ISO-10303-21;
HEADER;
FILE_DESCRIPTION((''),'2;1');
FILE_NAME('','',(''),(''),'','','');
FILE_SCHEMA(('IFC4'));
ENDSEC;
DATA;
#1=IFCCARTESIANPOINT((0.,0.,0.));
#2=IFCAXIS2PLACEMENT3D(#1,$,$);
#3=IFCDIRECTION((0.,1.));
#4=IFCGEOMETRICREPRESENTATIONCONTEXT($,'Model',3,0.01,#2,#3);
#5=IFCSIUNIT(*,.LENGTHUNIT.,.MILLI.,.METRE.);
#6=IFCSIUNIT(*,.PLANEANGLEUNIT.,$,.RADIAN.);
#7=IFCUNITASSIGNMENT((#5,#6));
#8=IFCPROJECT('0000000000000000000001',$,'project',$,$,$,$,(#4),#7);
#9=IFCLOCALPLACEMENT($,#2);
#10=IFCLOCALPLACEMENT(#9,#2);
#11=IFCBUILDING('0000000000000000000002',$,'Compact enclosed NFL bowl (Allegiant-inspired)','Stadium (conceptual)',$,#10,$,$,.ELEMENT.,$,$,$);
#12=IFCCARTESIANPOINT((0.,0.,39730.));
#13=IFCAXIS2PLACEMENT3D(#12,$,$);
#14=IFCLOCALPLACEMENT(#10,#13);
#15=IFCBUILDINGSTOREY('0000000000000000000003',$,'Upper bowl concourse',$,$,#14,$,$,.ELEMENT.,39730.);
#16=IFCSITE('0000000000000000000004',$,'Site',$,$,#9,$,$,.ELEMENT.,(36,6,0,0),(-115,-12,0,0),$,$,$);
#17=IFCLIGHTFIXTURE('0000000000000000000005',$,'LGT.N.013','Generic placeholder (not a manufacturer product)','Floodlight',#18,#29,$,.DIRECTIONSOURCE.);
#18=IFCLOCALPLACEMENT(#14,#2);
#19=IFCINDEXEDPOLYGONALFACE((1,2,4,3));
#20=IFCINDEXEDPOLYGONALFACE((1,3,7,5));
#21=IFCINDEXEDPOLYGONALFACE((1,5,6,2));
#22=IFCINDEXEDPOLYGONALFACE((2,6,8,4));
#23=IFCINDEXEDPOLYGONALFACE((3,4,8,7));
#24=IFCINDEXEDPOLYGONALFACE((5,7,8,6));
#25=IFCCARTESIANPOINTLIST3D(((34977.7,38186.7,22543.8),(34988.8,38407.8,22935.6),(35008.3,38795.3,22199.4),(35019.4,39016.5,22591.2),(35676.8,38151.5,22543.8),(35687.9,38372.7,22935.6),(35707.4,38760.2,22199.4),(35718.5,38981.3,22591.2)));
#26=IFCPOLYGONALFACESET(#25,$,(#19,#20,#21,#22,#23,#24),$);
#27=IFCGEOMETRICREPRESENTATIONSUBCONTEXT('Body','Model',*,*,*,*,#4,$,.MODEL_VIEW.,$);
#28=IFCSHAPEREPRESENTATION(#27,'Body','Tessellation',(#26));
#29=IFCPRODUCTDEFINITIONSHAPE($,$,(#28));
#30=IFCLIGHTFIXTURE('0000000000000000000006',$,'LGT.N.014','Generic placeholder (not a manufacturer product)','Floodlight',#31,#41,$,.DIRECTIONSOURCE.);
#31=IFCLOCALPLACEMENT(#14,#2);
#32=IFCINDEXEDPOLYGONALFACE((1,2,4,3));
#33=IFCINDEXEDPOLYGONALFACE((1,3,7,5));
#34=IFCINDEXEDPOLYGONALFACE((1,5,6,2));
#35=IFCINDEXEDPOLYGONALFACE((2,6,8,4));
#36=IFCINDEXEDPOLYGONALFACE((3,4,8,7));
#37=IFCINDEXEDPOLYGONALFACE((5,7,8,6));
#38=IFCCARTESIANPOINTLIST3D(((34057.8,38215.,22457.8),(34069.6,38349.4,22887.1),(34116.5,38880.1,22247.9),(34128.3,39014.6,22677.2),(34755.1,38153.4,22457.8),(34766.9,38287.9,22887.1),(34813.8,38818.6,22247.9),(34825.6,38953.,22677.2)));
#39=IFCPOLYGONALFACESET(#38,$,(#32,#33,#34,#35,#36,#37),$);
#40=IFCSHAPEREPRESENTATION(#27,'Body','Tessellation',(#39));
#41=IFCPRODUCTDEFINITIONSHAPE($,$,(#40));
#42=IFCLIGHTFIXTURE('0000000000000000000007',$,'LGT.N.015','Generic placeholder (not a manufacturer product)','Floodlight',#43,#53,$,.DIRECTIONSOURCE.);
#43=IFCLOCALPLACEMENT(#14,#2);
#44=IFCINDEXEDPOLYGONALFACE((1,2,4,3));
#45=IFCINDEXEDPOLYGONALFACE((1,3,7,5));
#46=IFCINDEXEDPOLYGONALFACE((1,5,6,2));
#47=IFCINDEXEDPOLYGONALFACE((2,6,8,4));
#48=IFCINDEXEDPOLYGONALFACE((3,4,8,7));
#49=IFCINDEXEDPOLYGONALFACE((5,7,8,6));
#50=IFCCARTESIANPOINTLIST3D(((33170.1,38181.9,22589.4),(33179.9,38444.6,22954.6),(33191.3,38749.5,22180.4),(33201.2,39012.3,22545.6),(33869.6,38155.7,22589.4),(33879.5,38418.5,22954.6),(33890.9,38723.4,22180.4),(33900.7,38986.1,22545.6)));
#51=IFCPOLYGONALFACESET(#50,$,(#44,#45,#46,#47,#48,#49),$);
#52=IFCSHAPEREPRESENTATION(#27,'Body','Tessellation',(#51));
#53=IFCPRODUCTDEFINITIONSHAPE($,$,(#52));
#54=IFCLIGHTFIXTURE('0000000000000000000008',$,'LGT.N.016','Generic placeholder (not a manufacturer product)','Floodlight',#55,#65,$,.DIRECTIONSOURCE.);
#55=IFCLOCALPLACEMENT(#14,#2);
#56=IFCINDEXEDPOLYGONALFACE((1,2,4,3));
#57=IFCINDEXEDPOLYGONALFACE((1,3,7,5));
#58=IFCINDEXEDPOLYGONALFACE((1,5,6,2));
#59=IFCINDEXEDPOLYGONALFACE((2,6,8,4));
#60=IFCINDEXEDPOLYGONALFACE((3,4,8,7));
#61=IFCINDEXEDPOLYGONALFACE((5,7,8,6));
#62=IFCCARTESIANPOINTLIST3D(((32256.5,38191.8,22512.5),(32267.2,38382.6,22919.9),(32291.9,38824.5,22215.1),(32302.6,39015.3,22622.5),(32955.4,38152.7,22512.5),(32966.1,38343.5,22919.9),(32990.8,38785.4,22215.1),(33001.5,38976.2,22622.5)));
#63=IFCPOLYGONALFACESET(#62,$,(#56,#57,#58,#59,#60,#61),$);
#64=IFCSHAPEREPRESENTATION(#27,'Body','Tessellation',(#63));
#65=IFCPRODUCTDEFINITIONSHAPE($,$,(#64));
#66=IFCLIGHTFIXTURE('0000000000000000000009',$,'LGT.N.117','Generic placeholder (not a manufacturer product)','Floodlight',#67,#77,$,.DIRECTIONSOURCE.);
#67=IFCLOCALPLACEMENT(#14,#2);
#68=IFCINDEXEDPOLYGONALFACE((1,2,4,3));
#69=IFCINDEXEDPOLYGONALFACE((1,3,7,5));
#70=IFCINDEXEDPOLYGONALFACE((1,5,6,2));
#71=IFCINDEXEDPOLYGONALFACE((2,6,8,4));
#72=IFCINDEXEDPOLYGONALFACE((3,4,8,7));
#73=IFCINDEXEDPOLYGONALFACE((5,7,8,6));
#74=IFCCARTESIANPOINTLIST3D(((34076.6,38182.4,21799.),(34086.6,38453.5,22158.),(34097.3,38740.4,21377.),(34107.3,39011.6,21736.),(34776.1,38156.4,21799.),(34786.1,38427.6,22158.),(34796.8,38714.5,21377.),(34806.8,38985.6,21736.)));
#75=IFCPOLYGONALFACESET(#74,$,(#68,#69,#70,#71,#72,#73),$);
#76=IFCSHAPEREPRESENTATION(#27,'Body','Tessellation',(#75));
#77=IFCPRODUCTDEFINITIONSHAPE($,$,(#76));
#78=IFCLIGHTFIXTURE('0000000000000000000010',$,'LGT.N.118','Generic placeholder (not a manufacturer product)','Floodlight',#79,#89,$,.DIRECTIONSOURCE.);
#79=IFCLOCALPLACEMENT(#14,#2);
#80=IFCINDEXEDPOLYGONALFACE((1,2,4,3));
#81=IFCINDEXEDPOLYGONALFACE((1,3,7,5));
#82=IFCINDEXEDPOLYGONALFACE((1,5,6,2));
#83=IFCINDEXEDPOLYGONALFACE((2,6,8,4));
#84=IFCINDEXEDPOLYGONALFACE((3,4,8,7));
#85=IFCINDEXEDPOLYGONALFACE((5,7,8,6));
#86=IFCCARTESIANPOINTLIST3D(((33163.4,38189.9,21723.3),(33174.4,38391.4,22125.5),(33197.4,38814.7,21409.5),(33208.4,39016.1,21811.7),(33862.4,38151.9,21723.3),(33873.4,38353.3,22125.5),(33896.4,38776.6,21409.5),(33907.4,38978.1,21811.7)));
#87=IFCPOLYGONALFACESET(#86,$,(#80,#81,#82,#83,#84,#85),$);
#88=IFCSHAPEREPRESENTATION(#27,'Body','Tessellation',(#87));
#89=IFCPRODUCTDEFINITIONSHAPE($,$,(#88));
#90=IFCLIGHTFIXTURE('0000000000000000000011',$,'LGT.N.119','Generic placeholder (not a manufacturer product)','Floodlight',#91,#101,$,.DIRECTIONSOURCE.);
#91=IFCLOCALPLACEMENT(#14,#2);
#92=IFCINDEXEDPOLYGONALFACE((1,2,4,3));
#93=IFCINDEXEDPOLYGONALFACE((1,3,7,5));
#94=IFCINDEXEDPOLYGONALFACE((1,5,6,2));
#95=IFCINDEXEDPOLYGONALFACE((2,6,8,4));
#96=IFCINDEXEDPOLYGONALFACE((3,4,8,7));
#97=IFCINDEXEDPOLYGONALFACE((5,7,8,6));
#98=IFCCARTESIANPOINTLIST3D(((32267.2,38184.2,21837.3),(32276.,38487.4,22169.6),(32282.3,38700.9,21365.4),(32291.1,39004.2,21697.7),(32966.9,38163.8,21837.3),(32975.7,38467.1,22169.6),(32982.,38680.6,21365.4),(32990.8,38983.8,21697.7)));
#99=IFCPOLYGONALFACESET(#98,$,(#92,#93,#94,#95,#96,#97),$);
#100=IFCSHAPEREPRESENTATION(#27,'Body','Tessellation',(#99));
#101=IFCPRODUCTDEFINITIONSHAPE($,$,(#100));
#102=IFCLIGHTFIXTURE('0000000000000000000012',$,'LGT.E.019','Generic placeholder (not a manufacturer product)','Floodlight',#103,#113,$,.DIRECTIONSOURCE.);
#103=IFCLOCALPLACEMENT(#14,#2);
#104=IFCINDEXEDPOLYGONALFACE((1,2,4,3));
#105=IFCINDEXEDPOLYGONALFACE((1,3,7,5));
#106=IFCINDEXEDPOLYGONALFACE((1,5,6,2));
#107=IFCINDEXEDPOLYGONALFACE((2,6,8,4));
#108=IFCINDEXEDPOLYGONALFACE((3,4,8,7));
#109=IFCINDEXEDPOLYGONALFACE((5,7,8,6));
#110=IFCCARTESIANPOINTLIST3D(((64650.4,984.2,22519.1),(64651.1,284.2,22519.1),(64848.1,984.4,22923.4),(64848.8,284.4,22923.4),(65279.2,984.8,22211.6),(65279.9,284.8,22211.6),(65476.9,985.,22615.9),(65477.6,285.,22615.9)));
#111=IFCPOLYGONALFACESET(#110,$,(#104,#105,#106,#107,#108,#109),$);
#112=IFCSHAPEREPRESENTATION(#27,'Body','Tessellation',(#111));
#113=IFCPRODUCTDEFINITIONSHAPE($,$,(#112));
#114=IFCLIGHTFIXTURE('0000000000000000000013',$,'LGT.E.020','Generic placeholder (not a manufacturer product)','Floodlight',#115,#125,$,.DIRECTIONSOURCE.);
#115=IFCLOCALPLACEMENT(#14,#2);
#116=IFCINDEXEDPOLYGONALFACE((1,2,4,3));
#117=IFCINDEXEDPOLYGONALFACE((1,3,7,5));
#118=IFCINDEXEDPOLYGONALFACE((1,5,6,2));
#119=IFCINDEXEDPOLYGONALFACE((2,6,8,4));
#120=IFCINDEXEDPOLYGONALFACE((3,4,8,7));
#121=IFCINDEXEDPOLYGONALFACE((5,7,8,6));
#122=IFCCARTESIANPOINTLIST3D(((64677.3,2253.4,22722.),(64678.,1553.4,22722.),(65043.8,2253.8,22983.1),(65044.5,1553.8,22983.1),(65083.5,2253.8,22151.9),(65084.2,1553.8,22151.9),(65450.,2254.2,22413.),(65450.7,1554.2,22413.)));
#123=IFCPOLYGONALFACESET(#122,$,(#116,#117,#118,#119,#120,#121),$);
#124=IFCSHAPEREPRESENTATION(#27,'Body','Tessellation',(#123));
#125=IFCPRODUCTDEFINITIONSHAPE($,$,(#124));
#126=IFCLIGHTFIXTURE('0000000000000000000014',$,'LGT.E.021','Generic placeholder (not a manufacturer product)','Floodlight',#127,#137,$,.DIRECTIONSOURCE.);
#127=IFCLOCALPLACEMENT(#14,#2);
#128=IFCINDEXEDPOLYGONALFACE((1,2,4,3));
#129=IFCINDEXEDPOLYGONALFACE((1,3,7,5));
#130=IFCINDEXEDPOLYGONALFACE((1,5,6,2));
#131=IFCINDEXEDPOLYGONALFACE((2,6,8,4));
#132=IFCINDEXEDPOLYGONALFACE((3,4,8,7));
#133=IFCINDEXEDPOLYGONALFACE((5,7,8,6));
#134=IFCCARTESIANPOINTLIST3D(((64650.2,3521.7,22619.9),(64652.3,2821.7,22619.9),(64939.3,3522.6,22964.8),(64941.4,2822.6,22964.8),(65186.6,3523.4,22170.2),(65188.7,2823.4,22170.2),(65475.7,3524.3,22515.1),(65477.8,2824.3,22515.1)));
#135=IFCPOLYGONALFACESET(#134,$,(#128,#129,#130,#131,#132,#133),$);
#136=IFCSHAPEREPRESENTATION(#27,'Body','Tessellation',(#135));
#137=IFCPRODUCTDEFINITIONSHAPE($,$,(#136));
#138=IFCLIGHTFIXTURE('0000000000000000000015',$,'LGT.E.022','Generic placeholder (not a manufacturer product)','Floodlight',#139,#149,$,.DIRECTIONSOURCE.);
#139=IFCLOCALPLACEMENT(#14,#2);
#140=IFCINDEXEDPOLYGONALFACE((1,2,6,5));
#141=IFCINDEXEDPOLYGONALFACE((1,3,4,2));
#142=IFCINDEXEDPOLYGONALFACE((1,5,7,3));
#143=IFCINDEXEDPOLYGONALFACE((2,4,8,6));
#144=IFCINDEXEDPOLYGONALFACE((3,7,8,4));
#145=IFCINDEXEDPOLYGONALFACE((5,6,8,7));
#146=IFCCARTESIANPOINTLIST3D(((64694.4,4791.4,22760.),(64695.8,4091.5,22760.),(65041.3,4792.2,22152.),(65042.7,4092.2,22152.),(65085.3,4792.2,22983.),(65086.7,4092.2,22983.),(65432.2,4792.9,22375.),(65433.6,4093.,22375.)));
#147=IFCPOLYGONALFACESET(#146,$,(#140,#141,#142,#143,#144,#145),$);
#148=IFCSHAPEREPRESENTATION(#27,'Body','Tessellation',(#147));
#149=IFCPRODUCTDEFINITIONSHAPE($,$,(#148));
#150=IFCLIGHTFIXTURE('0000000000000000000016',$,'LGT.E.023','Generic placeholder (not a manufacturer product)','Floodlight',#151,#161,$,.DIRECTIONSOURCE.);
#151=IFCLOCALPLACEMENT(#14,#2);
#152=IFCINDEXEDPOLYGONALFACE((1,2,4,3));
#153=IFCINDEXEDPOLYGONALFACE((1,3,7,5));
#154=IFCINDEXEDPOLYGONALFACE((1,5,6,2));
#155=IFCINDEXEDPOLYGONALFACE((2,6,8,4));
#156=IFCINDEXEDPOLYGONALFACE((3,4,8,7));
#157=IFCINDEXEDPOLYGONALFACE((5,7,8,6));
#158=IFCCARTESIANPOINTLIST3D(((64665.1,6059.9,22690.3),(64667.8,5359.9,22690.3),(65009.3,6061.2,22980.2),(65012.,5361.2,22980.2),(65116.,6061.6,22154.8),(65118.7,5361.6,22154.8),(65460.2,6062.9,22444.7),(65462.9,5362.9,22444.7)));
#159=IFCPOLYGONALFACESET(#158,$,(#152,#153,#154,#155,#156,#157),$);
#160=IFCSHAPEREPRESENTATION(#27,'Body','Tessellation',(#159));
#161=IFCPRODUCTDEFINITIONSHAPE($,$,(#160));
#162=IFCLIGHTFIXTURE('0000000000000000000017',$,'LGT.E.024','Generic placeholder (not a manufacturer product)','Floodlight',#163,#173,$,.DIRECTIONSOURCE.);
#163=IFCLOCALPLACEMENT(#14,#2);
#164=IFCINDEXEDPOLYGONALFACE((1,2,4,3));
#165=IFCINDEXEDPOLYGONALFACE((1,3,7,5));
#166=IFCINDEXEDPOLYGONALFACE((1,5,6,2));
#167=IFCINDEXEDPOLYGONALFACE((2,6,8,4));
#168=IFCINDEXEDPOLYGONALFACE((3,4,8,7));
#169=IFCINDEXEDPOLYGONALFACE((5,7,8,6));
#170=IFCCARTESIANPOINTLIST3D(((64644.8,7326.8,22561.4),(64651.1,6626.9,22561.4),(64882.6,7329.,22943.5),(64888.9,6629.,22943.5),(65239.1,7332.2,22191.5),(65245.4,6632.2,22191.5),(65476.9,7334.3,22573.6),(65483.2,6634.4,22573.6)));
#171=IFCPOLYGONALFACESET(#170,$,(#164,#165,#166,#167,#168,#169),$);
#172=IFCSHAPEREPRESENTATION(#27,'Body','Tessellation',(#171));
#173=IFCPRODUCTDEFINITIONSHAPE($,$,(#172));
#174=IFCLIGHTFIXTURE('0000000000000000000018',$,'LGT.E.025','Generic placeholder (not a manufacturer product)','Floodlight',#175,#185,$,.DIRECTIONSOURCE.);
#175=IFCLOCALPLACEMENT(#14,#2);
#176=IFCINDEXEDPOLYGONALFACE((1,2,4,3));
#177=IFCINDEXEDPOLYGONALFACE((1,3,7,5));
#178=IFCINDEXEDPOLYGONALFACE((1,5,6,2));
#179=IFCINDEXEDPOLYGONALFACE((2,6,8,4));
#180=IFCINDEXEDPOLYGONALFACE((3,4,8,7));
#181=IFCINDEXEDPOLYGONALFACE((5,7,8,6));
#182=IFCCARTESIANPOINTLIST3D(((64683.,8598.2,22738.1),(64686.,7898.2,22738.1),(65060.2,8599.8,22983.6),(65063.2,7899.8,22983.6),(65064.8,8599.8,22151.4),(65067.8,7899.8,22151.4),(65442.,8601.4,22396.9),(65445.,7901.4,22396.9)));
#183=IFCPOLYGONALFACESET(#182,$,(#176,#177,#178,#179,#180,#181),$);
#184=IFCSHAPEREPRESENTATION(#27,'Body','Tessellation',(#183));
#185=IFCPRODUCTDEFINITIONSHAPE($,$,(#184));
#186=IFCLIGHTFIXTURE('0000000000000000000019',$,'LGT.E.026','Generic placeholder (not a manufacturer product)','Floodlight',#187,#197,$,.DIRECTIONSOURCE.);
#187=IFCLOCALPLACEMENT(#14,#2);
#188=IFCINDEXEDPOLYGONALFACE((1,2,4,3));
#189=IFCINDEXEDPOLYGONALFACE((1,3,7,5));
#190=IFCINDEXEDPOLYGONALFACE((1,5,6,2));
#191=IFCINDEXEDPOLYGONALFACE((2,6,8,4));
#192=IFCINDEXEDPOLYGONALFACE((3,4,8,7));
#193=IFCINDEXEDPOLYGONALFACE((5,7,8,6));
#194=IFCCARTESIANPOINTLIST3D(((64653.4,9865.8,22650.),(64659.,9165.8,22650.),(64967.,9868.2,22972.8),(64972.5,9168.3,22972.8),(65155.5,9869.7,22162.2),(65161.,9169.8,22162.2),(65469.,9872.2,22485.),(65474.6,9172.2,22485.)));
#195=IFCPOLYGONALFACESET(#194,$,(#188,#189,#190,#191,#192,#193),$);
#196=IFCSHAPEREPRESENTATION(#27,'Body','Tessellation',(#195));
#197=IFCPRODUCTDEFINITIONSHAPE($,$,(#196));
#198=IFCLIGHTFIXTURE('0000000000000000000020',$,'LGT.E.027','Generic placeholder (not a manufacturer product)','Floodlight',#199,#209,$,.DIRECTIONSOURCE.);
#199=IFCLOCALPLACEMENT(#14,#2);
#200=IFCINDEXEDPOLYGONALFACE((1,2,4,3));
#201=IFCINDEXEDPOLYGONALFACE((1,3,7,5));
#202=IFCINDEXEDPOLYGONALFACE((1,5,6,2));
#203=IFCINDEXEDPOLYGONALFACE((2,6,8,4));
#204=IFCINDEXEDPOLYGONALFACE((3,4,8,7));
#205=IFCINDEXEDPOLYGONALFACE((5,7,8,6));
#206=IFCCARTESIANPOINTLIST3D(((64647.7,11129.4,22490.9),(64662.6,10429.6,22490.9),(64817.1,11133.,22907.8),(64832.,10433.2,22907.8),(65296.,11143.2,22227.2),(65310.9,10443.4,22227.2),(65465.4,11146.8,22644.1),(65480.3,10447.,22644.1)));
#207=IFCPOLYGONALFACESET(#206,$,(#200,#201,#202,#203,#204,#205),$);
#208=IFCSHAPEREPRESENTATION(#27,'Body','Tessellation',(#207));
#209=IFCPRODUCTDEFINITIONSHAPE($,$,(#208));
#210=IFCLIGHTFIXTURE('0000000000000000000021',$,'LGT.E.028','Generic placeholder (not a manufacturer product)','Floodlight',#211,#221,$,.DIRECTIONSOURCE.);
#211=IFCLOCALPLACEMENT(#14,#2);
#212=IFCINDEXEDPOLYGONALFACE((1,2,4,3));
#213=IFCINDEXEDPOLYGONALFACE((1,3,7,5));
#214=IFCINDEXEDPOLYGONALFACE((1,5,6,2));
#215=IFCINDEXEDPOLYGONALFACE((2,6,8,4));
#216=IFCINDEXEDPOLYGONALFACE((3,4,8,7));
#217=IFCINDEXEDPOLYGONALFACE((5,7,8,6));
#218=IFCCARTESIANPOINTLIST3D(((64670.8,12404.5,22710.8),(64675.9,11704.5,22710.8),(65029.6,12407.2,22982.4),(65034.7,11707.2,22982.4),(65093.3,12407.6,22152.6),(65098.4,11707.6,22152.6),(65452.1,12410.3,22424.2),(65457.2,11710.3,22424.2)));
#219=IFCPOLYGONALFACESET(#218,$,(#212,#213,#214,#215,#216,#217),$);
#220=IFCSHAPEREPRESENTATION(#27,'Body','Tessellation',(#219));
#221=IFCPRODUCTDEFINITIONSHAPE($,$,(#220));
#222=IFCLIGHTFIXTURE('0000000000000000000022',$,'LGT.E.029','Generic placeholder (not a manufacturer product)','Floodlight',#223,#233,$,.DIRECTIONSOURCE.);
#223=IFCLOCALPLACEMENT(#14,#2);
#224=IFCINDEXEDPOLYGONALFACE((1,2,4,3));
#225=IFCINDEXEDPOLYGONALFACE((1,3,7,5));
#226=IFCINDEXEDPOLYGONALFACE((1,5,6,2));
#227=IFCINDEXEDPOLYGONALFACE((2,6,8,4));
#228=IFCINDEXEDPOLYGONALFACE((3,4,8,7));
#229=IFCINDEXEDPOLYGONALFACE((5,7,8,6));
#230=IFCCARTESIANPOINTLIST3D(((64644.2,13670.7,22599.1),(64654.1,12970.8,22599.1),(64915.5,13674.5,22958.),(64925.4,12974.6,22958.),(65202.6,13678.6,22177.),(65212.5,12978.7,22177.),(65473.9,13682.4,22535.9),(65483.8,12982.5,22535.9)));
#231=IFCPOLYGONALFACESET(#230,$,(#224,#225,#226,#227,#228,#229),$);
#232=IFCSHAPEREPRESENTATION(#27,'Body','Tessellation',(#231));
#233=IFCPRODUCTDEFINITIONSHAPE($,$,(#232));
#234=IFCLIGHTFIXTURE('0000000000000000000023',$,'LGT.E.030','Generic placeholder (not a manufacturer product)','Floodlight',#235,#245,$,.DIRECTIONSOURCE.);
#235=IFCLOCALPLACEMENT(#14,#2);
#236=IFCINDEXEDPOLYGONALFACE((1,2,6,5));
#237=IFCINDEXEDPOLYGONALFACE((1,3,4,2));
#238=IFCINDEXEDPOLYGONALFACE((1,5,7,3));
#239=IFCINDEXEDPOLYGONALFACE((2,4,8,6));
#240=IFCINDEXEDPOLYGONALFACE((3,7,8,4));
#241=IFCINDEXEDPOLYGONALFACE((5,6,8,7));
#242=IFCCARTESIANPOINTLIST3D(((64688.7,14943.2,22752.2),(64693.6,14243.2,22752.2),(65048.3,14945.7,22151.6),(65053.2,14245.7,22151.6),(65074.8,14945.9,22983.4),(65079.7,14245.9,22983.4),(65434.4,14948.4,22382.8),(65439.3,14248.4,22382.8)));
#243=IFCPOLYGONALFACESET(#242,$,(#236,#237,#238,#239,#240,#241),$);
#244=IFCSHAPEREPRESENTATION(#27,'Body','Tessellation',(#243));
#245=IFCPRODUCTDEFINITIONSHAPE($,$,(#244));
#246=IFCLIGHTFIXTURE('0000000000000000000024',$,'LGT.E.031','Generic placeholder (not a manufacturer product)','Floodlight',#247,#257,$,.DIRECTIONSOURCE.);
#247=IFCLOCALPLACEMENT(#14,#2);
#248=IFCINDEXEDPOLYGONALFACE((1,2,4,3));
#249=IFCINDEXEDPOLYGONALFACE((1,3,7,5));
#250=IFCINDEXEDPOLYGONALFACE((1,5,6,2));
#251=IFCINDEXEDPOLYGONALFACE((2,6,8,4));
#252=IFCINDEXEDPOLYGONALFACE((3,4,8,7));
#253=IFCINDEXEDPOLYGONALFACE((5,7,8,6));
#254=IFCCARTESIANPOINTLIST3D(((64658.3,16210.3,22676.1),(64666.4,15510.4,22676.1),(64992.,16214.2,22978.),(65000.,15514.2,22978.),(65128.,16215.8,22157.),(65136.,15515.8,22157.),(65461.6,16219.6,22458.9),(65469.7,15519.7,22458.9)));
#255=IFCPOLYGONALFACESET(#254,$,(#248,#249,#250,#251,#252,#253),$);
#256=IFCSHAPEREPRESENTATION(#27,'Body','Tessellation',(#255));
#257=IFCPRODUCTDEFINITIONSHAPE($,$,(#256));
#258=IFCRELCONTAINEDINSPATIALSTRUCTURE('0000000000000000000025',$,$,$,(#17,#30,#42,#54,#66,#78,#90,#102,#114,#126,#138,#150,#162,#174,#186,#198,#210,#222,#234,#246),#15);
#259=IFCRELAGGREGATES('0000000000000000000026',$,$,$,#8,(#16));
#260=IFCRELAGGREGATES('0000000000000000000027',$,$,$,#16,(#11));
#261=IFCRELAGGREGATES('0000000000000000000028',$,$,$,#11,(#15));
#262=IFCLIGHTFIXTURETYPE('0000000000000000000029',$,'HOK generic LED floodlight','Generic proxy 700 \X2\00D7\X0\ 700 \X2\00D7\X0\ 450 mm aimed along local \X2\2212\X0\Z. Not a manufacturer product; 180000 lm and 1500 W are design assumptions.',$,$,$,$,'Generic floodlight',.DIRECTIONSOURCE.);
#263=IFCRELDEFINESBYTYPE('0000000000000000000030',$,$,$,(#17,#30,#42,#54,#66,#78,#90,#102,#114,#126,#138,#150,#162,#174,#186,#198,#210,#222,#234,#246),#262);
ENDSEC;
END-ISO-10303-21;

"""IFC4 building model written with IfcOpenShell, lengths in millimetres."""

from ifc_helpers import new_model, si_unit, direction, frame, origin, place, context, subcontext, project, spatial, rectangle, extrude, source, transform, mapped, type_object, type_shapes, element, save


model = new_model("IFC4")

# Units and contexts
model_context = context("Model", 3, precision=0.01, world=origin(), true_north=direction((0.0, 1.0)))
body_context = subcontext(model_context, "Body", "Model", "MODEL_VIEW")
ifc_project = project(units=[si_unit("LENGTHUNIT", "METRE", prefix="MILLI"), si_unit("PLANEANGLEUNIT", "RADIAN")], contexts=[model_context])

# Site, building, storey
site_placement = place(None, origin())
site = spatial("IfcSite", under=ifc_project, at=site_placement, Name="Site", CompositionType="ELEMENT", RefLatitude=(36, 6, 0, 0), RefLongitude=(-115, -12, 0, 0))
building_placement = place(site_placement, origin())
building = spatial("IfcBuilding", under=site, at=building_placement, Name="Compact enclosed NFL bowl (Allegiant-inspired)", Description="Stadium (conceptual)", CompositionType="ELEMENT")
storey_placement = place(building_placement, frame((0.0, 0.0, 39730.0)))
storey = spatial("IfcBuildingStorey", under=building, at=storey_placement, Name="Upper bowl concourse", CompositionType="ELEMENT", Elevation=39730.0)

# Light fixtures
light_fixture_type = type_object("IfcLightFixtureType", Name="HOK generic LED floodlight", Description="Generic proxy 700 × 700 × 450 mm aimed along local −Z. Not a manufacturer product; 180000 lm and 1500 W are design assumptions.", ElementType="Generic floodlight", PredefinedType="DIRECTIONSOURCE")
shared_shape = source(origin(), body_context, "Body", "SweptSolid", [
    extrude(rectangle(XDim=700.0, YDim=700.0), frame((0.0, 0.0, -225.0)), (0.0, 0.0, 1.0), 450.0),
])
type_shapes(light_fixture_type, [shared_shape])
for number, where, z_axis, x_axis, name in (
    (1, (35348.1, 38584.0, 22567.5), (0.0247, 0.491356, 0.870608), (-0.998739, 0.050205, 0.0), "LGT.N.013"),
    (2, (34441.7, 38584.0, 22567.5), (0.02637, 0.29879, 0.953954), (-0.996128, 0.087914, 0.0), "LGT.N.014"),
    (3, (33535.4, 38584.0, 22567.5), (0.021842, 0.583959, 0.811489), (-0.999301, 0.037377, 0.0), "LGT.N.015"),
    (4, (32629.0, 38584.0, 22567.5), (0.023708, 0.424088, 0.905311), (-0.998441, 0.055817, 0.0), "LGT.N.016"),
    (5, (34441.7, 38584.0, 21767.5), (0.02234, 0.602536, 0.797779), (-0.999313, 0.037051, 0.0), "LGT.N.117"),
    (6, (33535.4, 38584.0, 21767.5), (0.024372, 0.447673, 0.893865), (-0.998521, 0.054361, 0.0), "LGT.N.118"),
    (7, (32629.0, 38584.0, 21767.5), (0.019592, 0.673928, 0.738537), (-0.999578, 0.02906, 0.0), "LGT.N.119"),
    (8, (65064.0, 634.6, 22567.5), (0.439296, 0.000458, 0.898342), (-0.001042, 0.999999, 0.0), "LGT.E.019"),
    (9, (65064.0, 1903.8, 22567.5), (0.814402, 0.000887, 0.580301), (-0.001089, 0.999999, 0.0), "LGT.E.020"),
    (10, (65064.0, 3173.0, 22567.5), (0.642417, 0.001952, 0.766353), (-0.003038, 0.999995, 0.0), "LGT.E.021"),
    (11, (65064.0, 4442.2, 22567.5), (0.868569, 0.001767, 0.495565), (-0.002034, 0.999998, 0.0), "LGT.E.022"),
    (12, (65064.0, 5711.4, 22567.5), (0.764921, 0.002953, 0.644117), (-0.00386, 0.999993, 0.0), "LGT.E.023"),
    (13, (65064.0, 6980.6, 22567.5), (0.528415, 0.004756, 0.848973), (-0.009001, 0.999959, 0.0), "LGT.E.024"),
    (14, (65064.0, 8249.8, 22567.5), (0.838172, 0.003611, 0.545393), (-0.004308, 0.999991, 0.0), "LGT.E.025"),
    (15, (65064.0, 9519.0, 22567.5), (0.696871, 0.005479, 0.717175), (-0.007862, 0.999969, 0.0), "LGT.E.026"),
    (16, (65064.0, 10788.2, 22567.5), (0.376607, 0.008021, 0.926338), (-0.021293, 0.999773, 0.0), "LGT.E.027"),
    (17, (65064.0, 12057.4, 22567.5), (0.79729, 0.005841, 0.603568), (-0.007326, 0.999973, 0.0), "LGT.E.028"),
    (18, (65064.0, 13326.6, 22567.5), (0.602949, 0.008533, 0.797734), (-0.01415, 0.9999, 0.0), "LGT.E.029"),
    (19, (65064.0, 14595.8, 22567.5), (0.857962, 0.006018, 0.513678), (-0.007014, 0.999975, 0.0), "LGT.E.030"),
    (20, (65064.0, 15865.0, 22567.5), (0.741459, 0.008543, 0.670944), (-0.011522, 0.999934, 0.0), "LGT.E.031"),
):
    element("IfcLightFixture", number, at=place(storey_placement, frame(where, z_axis=z_axis, x_axis=x_axis)), inside=storey, type_object=light_fixture_type, Name=name, Description="Generic placeholder (not a manufacturer product)", ObjectType="Floodlight", PredefinedType="DIRECTIONSOURCE", context=body_context, shape_type="MappedRepresentation", body=[
        mapped(shared_shape, transform((0.0, 0.0, 0.0))),
    ])

save(model, "model.ifc")
